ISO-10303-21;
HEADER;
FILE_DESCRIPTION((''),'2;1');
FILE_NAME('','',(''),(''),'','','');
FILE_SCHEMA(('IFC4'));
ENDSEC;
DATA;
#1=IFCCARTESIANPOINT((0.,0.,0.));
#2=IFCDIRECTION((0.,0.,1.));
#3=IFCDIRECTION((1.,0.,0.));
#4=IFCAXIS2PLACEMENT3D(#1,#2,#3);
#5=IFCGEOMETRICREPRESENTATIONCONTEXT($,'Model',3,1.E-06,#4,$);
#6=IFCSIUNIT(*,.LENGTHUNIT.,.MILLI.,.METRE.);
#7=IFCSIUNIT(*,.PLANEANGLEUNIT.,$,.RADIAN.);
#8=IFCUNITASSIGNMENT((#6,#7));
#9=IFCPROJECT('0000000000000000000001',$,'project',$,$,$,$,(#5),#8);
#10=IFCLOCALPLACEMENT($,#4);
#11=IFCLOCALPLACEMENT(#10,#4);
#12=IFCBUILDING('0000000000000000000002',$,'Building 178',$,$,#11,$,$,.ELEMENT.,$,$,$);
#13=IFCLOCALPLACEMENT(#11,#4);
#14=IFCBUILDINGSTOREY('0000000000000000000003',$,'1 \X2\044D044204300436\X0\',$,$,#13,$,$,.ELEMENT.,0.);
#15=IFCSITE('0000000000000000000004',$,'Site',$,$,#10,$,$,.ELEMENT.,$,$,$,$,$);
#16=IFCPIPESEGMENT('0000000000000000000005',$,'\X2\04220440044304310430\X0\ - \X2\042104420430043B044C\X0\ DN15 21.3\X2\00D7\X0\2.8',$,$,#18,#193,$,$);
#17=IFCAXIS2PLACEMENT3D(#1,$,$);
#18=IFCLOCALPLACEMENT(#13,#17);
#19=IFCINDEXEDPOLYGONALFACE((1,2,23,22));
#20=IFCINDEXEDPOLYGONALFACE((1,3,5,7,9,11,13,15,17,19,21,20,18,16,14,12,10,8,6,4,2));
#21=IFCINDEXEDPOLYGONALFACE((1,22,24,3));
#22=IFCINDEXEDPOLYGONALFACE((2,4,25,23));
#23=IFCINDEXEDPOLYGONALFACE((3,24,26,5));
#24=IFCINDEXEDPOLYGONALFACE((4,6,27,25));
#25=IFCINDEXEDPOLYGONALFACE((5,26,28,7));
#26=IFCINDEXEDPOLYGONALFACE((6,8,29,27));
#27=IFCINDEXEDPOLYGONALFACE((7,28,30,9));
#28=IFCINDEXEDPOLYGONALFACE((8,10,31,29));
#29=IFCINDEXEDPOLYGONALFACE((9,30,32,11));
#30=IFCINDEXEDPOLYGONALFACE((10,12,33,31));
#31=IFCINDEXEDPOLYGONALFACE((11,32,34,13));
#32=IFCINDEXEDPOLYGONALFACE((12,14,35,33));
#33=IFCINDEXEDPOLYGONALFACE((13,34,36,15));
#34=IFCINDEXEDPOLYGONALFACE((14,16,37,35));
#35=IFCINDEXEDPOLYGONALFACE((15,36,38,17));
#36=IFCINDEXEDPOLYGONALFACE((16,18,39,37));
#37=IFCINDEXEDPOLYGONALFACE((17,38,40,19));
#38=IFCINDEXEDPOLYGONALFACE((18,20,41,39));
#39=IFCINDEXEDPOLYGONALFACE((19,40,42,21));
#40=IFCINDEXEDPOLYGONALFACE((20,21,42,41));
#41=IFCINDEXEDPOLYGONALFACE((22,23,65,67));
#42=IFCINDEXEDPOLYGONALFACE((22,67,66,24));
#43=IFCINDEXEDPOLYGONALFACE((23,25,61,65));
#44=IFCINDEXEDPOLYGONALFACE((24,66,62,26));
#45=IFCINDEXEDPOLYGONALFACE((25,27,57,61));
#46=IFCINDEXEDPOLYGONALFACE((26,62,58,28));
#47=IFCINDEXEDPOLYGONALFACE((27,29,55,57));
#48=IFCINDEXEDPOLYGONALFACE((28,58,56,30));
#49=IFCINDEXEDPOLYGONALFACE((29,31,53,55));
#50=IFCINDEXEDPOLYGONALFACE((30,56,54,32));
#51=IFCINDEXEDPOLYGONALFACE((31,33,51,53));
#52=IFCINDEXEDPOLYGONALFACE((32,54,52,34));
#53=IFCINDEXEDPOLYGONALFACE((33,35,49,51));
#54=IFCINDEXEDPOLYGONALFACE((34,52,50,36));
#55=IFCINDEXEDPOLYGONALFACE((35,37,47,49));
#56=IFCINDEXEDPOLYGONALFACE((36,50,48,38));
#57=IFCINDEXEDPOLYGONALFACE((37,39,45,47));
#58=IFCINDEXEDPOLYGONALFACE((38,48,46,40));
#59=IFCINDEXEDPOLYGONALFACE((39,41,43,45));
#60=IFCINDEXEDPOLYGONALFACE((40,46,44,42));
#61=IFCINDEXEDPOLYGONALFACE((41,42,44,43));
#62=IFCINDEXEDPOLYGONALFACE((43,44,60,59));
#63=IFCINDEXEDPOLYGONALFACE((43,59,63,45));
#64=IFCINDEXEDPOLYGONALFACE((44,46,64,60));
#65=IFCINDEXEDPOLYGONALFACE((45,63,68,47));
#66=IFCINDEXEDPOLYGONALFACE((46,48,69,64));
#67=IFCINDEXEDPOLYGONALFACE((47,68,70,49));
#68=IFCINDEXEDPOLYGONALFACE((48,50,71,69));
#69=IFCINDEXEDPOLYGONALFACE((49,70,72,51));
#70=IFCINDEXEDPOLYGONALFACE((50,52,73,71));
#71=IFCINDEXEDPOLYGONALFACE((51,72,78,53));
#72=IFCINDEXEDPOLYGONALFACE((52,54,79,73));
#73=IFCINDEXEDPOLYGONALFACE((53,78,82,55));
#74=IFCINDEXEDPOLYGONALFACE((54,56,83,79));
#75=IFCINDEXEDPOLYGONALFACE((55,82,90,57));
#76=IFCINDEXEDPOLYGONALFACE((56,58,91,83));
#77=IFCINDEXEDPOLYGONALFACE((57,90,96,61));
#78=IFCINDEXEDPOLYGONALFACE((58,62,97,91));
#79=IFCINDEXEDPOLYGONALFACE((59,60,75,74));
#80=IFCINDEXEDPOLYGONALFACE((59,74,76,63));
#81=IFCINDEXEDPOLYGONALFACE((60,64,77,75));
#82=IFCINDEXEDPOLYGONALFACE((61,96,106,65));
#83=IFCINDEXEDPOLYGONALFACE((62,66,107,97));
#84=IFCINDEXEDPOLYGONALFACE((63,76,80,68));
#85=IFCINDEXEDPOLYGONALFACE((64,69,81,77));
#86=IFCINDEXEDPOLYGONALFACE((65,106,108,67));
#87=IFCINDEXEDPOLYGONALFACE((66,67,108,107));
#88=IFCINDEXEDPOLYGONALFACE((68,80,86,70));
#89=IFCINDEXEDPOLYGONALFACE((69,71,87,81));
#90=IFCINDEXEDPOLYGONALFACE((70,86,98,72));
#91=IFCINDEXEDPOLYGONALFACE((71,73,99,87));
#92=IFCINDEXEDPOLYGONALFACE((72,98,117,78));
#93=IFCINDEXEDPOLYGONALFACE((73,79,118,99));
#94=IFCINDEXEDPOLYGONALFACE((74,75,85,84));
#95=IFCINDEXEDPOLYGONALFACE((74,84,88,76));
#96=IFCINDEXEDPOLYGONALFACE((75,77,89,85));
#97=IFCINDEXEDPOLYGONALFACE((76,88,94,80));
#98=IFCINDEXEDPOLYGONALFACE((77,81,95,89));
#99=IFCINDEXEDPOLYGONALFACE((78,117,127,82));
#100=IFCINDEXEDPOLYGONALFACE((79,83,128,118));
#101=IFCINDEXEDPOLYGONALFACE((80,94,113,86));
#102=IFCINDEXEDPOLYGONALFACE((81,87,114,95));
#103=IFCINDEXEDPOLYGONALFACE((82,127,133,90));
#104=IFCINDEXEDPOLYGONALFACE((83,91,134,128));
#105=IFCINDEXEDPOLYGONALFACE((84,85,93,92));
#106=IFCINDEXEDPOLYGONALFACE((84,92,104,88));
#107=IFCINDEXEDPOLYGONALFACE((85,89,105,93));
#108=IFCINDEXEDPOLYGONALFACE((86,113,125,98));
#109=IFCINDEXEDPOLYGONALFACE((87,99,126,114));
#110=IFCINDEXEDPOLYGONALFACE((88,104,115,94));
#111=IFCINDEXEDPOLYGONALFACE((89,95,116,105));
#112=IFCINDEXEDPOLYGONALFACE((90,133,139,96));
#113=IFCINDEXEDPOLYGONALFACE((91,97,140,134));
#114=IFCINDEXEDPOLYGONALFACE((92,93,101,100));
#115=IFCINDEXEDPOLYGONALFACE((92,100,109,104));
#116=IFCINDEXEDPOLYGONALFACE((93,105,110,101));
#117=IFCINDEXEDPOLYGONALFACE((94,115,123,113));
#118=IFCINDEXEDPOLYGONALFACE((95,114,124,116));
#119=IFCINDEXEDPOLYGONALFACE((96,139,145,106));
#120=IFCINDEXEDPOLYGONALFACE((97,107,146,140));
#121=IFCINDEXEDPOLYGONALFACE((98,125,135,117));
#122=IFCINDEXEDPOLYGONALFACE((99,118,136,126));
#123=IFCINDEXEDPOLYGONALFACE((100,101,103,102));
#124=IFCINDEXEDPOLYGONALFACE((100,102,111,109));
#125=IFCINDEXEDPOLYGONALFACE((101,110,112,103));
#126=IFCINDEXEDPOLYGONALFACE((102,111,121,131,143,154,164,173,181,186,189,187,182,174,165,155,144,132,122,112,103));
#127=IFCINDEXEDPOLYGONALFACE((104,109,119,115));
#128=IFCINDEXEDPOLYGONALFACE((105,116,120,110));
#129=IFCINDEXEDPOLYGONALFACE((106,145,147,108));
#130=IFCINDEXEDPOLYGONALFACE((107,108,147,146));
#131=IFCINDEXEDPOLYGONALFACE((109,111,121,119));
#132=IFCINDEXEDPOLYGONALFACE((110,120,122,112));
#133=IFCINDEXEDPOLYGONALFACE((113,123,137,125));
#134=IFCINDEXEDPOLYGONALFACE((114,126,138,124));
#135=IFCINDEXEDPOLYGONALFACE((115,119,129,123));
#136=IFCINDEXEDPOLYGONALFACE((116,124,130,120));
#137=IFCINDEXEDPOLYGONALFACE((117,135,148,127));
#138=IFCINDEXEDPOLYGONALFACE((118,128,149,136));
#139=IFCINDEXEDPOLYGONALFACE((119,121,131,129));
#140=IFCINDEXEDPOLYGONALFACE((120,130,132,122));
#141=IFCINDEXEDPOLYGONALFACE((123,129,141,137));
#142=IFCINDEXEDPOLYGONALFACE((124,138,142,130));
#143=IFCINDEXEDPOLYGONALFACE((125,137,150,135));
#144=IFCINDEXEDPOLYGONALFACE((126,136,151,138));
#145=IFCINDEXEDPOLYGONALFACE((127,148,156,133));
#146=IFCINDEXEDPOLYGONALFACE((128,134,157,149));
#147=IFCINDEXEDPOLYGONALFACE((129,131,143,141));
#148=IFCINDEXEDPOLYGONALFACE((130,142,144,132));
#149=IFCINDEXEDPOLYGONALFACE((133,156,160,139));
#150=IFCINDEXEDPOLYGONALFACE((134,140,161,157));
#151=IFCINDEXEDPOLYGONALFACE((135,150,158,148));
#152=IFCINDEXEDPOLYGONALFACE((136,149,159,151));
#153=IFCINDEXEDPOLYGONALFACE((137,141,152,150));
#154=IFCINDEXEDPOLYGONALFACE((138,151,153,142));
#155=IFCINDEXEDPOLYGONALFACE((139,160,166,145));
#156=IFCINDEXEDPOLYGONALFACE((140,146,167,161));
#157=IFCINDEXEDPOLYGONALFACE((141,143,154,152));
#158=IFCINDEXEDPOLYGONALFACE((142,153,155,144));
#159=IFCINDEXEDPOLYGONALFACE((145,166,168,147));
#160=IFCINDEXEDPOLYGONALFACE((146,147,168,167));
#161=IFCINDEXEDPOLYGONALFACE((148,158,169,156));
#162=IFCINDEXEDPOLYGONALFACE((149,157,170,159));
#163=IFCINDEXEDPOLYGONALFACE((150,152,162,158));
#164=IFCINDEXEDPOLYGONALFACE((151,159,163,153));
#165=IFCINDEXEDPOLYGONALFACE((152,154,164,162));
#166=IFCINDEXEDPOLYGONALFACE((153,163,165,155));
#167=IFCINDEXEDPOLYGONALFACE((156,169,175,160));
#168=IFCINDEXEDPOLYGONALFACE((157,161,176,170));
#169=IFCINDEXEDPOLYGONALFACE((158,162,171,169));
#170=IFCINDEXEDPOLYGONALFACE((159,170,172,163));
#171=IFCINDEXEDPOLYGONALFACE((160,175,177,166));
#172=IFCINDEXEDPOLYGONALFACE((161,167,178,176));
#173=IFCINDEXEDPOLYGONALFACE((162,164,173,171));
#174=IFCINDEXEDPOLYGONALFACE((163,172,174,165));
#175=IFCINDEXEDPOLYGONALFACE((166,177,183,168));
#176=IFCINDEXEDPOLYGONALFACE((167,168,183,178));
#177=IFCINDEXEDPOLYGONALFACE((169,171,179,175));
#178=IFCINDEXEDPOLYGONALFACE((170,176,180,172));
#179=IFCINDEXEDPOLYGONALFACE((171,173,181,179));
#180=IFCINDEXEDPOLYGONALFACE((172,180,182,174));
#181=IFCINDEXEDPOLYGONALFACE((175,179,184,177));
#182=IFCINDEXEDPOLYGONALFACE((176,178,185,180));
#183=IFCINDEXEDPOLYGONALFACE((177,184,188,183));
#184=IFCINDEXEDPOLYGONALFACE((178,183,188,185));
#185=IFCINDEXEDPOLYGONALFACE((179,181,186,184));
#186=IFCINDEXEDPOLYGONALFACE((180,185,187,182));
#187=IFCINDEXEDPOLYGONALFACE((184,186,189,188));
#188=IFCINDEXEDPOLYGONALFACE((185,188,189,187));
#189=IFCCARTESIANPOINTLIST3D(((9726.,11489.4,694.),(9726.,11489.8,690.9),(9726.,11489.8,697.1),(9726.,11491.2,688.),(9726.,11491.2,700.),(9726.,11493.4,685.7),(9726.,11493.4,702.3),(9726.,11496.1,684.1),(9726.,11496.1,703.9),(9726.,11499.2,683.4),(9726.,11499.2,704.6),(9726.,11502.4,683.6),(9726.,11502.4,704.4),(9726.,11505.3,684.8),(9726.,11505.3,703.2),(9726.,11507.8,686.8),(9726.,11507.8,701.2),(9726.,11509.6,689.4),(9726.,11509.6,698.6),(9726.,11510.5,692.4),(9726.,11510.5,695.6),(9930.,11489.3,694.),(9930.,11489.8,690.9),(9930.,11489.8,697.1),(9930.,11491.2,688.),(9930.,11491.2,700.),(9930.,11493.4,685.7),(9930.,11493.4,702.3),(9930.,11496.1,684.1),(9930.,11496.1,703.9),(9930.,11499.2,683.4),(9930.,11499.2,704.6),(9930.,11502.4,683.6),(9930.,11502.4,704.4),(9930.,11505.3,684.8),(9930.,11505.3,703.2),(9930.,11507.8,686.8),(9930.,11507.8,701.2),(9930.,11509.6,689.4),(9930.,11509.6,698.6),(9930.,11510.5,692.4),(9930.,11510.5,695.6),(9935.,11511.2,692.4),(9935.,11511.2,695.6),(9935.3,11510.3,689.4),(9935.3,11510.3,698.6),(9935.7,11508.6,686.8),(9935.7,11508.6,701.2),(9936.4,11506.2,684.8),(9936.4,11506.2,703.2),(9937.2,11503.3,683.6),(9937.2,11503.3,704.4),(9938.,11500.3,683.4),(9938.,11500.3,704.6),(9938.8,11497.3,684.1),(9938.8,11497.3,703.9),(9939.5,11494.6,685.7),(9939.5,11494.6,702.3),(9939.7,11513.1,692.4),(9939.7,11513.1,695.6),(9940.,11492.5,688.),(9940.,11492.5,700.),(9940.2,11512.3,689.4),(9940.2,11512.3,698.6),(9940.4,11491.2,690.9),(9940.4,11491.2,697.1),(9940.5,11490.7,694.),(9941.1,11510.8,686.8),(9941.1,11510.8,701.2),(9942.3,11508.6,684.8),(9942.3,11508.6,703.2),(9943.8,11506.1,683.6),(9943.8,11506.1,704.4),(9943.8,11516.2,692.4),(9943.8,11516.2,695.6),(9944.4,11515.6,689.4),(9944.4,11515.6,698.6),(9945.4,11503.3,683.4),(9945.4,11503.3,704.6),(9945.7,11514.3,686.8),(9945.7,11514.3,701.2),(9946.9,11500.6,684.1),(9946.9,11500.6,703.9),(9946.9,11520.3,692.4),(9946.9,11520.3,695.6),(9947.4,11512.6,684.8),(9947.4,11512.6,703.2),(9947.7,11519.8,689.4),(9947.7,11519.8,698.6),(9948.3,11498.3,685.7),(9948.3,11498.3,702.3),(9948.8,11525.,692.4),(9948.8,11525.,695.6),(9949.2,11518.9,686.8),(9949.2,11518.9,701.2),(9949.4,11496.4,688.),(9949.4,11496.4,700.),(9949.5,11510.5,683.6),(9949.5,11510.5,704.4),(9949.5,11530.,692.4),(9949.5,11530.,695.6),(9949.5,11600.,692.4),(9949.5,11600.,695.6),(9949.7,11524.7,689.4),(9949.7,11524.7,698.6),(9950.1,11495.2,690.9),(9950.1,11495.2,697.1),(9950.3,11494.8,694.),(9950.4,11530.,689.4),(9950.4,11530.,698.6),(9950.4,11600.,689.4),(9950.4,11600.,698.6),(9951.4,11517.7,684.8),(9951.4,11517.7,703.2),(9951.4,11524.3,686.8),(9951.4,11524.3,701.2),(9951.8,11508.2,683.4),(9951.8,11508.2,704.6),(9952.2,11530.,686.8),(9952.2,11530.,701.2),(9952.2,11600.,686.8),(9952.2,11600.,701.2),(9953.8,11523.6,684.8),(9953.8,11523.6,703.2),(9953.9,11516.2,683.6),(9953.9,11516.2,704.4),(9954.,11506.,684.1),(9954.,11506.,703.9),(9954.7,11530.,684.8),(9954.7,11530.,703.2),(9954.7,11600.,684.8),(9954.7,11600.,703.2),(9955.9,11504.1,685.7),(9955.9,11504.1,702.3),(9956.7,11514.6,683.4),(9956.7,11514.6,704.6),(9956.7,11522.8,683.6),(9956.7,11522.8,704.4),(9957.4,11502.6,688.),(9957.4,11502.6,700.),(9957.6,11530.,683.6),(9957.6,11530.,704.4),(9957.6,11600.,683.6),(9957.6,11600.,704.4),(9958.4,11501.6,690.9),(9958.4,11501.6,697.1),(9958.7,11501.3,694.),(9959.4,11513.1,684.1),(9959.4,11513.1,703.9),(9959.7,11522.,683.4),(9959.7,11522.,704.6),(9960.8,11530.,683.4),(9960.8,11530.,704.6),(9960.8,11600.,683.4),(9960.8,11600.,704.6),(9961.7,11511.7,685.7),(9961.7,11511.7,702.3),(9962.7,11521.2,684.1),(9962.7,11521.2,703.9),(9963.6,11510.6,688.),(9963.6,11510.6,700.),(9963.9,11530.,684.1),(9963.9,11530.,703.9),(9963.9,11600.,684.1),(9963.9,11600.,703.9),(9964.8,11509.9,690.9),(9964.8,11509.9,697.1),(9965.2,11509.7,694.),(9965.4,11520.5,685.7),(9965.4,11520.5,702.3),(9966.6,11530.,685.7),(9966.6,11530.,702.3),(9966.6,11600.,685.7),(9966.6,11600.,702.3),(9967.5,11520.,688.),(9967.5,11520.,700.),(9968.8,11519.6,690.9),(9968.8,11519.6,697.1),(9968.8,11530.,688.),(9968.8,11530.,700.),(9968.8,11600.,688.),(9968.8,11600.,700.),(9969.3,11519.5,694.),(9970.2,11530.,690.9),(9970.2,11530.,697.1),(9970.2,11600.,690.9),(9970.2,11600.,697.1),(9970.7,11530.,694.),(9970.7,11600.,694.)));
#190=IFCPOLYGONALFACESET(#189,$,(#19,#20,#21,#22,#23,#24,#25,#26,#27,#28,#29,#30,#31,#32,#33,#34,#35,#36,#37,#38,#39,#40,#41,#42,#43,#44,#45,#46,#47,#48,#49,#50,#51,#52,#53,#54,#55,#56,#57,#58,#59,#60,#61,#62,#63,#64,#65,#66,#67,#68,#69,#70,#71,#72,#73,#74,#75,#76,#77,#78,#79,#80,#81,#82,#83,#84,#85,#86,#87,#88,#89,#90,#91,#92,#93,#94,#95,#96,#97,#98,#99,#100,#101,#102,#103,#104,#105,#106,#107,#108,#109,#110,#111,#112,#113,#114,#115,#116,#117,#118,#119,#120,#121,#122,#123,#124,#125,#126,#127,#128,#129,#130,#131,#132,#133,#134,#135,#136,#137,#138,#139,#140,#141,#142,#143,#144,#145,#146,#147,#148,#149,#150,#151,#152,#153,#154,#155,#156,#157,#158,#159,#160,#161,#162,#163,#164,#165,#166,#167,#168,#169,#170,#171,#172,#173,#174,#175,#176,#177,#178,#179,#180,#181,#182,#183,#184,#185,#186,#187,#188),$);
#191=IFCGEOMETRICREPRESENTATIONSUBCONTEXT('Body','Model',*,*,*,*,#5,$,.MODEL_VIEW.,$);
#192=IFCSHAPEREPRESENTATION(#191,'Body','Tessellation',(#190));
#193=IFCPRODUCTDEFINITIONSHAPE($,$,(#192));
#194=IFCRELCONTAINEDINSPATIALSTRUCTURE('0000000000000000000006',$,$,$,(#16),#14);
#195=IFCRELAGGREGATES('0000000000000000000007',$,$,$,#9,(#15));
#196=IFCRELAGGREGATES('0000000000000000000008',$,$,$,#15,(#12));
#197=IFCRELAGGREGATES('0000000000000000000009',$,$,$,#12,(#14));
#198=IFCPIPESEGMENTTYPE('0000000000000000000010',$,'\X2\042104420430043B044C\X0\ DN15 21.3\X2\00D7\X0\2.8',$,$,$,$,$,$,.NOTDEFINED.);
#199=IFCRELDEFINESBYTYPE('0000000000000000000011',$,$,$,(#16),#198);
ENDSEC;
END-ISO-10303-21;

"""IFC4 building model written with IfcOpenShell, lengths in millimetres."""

from ifc_helpers import new_model, entity, si_unit, frame, origin_with_axes, place, context, subcontext, project, spatial, source, transform, mapped, type_object, element, save


model = new_model("IFC4")

# Units and contexts
model_context = context("Model", 3, precision=1e-06, world=origin_with_axes())
body_context = subcontext(model_context, "Body", "Model", "MODEL_VIEW")
ifc_project = project(units=[si_unit("LENGTHUNIT", "METRE", prefix="MILLI"), si_unit("PLANEANGLEUNIT", "RADIAN")], contexts=[model_context])

# Site, building, storey
site_placement = place(None, origin_with_axes())
site = spatial("IfcSite", under=ifc_project, at=site_placement, Name="Site", CompositionType="ELEMENT")
building_placement = place(site_placement, origin_with_axes())
building = spatial("IfcBuilding", under=site, at=building_placement, Name="Building 178", CompositionType="ELEMENT")
storey_placement = place(building_placement, origin_with_axes())
storey = spatial("IfcBuildingStorey", under=building, at=storey_placement, Name="1 этаж", CompositionType="ELEMENT", Elevation=0.0)

# Pipe segment
pipe_segment_type = type_object("IfcPipeSegmentType", Name="Сталь DN15 21.3×2.8", PredefinedType="NOTDEFINED")
shared_shape_1 = source(origin_with_axes(), body_context, "Body", "AdvancedSweptSolid", [
    entity("IfcSweptDiskSolid", entity("IfcIndexedPolyCurve", entity("IfcCartesianPointList3D", [[0.0, 0.0, 0.0], [0.0, 0.0, -70.0], [8.8, 0.0, -91.2], [30.0, 0.0, -100.0], [234.0, 0.0, -100.0]]), [entity("IfcLineIndex", [1, 2]), entity("IfcArcIndex", [2, 3, 4]), entity("IfcLineIndex", [4, 5])]), 10.7),
])
for number, where, z_axis, x_axis, name in (
    (1, (9960.0, 11600.0, 694.0), (0.0, 1.0, 0.0), (-1.0, 0.0, 0.0), "Труба - Сталь DN15 21.3×2.8"),
):
    element("IfcPipeSegment", number, at=place(storey_placement, frame(where, z_axis=z_axis, x_axis=x_axis)), inside=storey, type_object=pipe_segment_type, Name=name, context=body_context, shape_type="MappedRepresentation", body=[
        mapped(shared_shape_1, transform((0.0, 0.0, 0.0), x_axis=(1.0, 0.0, 0.0), y_axis=(0.0, 1.0, 0.0), z_axis=(0.0, 0.0, 1.0), scale=1.0)),
    ])

save(model, "model.ifc")
